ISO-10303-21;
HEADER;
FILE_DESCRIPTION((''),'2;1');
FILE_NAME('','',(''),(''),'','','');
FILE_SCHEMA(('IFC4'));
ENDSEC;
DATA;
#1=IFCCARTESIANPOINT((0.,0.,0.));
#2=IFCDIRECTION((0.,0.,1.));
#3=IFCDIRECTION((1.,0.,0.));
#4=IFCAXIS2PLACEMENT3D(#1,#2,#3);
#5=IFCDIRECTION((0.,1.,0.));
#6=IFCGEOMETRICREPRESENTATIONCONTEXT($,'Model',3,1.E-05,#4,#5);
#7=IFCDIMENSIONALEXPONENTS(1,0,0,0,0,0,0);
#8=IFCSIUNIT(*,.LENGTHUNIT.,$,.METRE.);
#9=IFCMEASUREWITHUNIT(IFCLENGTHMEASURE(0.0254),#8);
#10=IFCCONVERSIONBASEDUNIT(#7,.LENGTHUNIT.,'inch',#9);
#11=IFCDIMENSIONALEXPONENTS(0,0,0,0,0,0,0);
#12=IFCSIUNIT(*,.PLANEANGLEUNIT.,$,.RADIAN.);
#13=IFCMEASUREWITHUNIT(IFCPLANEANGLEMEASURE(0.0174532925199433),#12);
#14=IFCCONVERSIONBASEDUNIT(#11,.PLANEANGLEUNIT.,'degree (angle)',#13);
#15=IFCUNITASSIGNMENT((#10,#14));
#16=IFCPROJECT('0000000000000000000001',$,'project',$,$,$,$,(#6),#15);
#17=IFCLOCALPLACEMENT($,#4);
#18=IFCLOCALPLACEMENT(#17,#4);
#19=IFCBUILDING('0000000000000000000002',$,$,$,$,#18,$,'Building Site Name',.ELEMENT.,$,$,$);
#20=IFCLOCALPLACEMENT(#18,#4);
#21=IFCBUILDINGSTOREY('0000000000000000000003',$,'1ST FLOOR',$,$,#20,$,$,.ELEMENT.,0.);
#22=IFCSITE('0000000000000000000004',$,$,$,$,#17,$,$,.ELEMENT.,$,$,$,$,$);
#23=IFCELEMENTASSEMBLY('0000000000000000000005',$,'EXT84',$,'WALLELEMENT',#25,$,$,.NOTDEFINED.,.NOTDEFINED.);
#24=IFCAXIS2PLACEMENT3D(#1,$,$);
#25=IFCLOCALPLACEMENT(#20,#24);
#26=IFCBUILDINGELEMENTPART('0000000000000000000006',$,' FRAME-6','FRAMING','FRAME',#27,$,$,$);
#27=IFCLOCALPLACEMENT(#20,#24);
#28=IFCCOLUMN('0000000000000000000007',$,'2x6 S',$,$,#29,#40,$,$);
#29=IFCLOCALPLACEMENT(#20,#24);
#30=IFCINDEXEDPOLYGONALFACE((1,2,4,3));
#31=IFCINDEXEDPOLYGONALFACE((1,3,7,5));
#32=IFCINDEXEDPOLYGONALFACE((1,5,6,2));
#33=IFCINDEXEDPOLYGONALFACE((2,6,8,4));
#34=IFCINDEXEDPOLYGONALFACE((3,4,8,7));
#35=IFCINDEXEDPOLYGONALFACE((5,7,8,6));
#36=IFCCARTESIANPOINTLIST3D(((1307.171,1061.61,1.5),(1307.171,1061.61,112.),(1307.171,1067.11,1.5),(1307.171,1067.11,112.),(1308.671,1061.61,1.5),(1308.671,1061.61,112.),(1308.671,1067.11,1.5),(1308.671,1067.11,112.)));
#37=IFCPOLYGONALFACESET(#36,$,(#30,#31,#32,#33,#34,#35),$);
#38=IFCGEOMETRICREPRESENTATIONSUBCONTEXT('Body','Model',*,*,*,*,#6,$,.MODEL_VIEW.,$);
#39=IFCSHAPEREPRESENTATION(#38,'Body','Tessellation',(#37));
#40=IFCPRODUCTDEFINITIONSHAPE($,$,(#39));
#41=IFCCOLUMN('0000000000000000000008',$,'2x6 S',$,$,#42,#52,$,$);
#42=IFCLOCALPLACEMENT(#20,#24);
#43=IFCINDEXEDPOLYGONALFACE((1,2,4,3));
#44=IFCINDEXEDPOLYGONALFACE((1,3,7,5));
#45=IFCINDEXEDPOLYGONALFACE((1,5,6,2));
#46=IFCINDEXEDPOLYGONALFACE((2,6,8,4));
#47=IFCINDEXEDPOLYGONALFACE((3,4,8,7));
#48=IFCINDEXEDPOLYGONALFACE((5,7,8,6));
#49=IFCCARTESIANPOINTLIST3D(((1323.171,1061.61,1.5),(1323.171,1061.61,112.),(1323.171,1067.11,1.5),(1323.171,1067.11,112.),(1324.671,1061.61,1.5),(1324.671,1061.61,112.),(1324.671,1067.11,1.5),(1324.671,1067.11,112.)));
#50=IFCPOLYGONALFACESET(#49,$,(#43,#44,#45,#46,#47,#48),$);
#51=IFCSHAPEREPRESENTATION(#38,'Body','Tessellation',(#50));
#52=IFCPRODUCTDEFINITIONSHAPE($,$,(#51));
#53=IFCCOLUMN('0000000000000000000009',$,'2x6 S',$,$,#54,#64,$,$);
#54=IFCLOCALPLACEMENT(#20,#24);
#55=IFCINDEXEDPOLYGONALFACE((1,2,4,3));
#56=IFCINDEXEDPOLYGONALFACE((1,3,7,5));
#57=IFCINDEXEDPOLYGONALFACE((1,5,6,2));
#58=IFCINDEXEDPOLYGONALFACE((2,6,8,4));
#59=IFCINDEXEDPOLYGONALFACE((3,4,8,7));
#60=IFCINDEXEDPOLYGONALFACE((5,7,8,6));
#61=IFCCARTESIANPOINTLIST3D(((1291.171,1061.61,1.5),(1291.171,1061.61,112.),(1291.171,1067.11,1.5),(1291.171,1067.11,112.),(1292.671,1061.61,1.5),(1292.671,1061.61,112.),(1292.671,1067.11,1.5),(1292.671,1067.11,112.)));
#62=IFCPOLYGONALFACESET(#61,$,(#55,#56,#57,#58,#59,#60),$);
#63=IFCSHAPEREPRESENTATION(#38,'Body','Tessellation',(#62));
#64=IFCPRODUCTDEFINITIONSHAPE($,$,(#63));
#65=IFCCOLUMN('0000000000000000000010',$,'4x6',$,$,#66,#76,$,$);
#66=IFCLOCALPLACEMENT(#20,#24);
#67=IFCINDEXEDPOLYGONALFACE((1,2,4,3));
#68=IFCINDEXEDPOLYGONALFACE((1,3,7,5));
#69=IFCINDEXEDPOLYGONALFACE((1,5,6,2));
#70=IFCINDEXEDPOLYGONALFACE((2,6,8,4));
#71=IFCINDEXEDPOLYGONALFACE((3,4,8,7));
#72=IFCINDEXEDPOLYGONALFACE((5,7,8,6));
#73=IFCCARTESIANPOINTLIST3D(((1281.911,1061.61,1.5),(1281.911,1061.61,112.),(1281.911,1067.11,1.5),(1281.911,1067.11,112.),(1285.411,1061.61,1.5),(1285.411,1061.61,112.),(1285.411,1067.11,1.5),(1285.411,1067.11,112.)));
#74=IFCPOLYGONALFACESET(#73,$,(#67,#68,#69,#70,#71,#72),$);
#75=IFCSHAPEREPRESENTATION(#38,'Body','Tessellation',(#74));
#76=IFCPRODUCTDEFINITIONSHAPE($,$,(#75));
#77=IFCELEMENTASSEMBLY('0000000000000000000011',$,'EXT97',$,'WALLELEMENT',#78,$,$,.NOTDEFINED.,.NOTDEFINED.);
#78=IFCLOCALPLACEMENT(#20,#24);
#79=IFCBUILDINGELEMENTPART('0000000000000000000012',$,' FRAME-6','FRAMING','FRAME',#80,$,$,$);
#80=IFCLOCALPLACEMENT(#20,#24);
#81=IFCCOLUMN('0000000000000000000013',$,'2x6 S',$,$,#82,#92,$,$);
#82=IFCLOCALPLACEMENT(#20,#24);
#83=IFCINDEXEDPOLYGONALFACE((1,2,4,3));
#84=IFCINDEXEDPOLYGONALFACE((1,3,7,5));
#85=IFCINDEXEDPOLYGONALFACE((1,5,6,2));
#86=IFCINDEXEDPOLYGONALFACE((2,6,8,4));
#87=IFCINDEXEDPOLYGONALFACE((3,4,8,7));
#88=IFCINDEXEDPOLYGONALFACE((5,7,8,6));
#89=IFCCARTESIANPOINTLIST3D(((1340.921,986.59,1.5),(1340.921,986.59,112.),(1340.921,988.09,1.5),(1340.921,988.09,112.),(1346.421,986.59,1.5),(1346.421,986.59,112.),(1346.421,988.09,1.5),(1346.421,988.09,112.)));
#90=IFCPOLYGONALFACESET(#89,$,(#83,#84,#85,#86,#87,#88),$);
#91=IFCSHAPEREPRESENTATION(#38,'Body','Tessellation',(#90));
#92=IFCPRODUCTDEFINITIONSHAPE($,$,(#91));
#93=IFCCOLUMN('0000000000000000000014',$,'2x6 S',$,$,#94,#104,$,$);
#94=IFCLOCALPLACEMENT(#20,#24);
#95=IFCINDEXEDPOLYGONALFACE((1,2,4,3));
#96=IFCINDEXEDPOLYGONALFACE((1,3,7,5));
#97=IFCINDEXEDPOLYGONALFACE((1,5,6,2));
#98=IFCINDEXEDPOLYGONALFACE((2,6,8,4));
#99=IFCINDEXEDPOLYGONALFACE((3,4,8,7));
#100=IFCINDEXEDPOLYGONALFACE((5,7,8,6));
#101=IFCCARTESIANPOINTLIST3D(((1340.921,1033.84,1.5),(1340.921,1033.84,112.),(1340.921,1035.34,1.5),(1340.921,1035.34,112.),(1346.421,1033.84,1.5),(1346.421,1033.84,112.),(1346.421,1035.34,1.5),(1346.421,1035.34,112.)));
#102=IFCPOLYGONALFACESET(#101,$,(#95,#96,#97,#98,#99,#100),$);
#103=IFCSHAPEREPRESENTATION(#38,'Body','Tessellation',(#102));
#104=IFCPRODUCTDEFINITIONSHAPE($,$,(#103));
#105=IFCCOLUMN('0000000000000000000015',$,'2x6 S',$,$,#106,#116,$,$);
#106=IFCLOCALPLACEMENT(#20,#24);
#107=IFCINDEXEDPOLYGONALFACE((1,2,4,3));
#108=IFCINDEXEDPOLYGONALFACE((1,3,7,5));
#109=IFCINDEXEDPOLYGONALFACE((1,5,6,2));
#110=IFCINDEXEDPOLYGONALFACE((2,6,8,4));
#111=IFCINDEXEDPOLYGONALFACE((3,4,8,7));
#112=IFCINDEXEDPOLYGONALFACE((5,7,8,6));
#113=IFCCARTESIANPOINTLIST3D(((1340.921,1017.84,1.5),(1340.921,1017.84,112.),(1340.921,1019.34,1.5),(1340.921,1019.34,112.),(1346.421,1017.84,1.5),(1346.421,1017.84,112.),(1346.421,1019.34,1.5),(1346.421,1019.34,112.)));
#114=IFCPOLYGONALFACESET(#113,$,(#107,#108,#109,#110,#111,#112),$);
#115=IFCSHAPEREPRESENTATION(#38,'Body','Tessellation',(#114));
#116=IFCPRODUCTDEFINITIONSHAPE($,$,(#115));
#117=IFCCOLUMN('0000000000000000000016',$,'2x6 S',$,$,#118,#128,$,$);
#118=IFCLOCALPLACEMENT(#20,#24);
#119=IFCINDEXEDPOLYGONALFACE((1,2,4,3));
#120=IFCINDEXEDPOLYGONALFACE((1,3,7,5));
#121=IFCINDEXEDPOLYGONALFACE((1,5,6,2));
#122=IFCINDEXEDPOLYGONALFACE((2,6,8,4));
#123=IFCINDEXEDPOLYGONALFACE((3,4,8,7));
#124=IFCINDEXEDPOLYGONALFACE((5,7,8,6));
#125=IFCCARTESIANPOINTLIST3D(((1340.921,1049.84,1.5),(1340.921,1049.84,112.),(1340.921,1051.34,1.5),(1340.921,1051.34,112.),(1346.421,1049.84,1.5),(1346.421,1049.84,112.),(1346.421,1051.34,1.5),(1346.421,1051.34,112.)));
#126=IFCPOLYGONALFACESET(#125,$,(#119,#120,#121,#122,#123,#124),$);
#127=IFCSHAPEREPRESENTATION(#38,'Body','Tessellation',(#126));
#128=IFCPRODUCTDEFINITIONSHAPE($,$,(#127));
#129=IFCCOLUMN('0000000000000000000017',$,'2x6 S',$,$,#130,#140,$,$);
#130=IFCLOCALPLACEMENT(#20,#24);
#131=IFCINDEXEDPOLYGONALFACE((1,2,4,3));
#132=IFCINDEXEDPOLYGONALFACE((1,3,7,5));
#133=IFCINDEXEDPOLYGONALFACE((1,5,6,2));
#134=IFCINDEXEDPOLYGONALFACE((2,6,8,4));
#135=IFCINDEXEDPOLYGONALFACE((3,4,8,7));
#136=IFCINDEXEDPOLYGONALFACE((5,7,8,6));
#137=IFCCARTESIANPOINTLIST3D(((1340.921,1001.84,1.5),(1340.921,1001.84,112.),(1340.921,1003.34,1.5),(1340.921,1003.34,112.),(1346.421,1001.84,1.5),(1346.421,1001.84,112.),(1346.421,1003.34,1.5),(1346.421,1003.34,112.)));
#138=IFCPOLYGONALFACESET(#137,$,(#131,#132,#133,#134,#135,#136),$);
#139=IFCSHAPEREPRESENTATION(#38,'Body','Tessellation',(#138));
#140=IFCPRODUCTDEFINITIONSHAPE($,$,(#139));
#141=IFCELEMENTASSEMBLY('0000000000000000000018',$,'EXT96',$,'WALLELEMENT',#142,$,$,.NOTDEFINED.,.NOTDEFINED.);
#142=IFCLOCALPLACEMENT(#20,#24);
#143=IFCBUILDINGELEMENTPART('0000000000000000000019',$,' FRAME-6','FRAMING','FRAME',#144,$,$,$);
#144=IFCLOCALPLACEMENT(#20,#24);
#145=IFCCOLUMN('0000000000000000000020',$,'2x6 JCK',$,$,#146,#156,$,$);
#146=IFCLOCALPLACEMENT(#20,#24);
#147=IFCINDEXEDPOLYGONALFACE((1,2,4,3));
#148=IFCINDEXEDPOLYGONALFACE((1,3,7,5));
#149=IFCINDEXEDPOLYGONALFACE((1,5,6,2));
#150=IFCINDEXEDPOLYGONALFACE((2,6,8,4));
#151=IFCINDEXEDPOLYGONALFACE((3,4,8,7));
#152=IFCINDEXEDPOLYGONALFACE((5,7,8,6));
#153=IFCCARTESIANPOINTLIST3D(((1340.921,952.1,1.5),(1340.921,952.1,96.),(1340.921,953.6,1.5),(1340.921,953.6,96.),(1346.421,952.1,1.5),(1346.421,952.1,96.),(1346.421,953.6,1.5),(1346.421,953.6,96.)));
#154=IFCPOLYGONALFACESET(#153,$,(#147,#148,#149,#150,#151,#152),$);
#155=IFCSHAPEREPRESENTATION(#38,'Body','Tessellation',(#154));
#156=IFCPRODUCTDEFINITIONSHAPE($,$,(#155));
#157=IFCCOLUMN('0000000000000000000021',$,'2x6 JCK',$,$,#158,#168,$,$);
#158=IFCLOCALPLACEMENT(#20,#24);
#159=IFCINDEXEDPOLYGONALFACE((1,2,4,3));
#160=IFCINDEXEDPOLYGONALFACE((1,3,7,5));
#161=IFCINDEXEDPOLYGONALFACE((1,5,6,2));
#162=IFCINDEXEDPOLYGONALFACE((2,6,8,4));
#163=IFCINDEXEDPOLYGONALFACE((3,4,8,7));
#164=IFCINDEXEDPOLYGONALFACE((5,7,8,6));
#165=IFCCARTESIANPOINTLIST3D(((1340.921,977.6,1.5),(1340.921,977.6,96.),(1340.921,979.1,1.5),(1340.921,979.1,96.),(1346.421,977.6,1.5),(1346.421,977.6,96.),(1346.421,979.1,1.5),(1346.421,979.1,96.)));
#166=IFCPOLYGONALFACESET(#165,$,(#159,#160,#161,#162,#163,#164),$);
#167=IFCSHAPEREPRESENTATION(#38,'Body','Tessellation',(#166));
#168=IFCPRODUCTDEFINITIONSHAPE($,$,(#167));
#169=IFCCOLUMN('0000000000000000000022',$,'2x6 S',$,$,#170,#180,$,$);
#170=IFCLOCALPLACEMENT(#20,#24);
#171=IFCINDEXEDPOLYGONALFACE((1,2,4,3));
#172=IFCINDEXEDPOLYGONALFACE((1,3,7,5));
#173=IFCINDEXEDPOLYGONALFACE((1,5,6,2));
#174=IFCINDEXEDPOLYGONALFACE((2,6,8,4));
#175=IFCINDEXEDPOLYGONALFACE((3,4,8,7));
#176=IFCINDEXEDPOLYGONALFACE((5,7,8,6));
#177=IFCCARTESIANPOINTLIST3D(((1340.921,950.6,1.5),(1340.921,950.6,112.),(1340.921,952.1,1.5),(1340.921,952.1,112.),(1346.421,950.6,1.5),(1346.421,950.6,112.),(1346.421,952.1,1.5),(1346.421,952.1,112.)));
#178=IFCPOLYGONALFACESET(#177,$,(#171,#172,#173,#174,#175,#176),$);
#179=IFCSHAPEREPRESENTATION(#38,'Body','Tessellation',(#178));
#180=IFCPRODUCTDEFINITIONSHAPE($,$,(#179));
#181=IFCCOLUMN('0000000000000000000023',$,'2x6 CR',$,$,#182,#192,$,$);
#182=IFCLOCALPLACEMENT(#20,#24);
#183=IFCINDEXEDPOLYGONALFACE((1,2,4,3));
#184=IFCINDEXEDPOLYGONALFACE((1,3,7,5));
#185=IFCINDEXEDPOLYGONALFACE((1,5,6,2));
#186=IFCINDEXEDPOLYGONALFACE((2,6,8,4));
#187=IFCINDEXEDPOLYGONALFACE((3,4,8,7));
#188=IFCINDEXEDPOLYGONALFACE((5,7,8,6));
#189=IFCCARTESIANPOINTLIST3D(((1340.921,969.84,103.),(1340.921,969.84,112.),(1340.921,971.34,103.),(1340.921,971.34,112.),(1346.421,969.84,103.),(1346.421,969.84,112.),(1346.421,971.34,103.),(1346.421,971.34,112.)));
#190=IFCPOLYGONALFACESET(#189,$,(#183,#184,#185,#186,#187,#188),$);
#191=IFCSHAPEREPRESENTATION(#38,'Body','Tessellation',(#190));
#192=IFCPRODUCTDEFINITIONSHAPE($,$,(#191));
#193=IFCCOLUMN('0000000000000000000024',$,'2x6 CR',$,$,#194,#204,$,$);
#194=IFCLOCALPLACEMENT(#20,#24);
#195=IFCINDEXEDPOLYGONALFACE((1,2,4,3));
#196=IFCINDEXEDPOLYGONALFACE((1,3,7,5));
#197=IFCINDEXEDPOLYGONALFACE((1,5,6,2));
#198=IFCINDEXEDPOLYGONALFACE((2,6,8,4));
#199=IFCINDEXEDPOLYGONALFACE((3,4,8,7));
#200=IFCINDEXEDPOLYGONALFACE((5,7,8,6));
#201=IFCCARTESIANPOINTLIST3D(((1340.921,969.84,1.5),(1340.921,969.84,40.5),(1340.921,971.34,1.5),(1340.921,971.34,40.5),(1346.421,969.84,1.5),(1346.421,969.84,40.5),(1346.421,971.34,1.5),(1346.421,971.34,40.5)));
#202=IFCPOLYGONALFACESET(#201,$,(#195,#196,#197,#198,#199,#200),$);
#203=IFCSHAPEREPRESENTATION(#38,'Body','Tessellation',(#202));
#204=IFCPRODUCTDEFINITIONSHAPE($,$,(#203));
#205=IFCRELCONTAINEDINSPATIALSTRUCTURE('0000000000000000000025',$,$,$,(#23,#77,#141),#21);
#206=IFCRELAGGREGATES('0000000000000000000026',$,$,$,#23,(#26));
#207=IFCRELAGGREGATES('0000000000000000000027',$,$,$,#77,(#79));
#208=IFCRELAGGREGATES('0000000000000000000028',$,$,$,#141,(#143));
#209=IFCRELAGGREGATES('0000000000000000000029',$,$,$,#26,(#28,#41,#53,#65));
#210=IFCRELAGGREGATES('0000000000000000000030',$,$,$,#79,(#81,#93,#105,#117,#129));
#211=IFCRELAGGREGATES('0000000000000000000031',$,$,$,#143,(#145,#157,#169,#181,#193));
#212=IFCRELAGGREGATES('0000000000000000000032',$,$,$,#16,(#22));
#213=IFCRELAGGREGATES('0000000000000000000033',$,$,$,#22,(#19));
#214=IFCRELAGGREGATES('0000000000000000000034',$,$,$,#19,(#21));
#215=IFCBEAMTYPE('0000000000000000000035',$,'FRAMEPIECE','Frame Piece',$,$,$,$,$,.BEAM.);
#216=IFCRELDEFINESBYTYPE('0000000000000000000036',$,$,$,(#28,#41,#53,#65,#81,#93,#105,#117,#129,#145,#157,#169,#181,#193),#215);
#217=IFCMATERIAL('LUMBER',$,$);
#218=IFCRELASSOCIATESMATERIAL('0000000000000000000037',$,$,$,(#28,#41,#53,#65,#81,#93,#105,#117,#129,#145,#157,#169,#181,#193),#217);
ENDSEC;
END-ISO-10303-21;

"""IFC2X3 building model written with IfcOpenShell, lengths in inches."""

from ifc_helpers import new_model, entity, si_unit, converted_unit, direction, frame, frame_2d, origin_with_axes, place, context, subcontext, project, spatial, polyline, segment, composite_curve, rectangle, outline, extrude, material, type_object, element, aggregate, save


model = new_model("IFC2X3")

# Units and contexts
model_context = context("Model", 3, precision=1e-05, world=origin_with_axes(), true_north=direction((0.0, 1.0, 0.0)))
body_context = subcontext(model_context, "Body", "Model", "MODEL_VIEW")
ifc_project = project(units=[converted_unit("LENGTHUNIT", "inch", entity("IfcLengthMeasure", 0.0254), si_unit("LENGTHUNIT", "METRE"), dimensions=[1, 0, 0, 0, 0, 0, 0]), converted_unit("PLANEANGLEUNIT", "degree (angle)", entity("IfcPlaneAngleMeasure", 0.0174532925199433), si_unit("PLANEANGLEUNIT", "RADIAN"), dimensions=[0, 0, 0, 0, 0, 0, 0])], contexts=[model_context])

# Site, building, storey
site_placement = place(None, origin_with_axes())
site = spatial("IfcSite", under=ifc_project, at=site_placement, CompositionType="ELEMENT")
building_placement = place(site_placement, origin_with_axes())
building = spatial("IfcBuilding", under=site, at=building_placement, LongName="Building Site Name", CompositionType="ELEMENT")
storey_placement = place(building_placement, origin_with_axes())
storey = spatial("IfcBuildingStorey", under=building, at=storey_placement, Name="1ST FLOOR", CompositionType="ELEMENT", Elevation=0.0)

# Element assemblies, building element parts, columns
assembly_1_placement = place(storey_placement, origin_with_axes())
assembly_1 = element("IfcElementAssembly", 1, at=assembly_1_placement, inside=storey, Name="EXT84", ObjectType="WALLELEMENT", AssemblyPlace="NOTDEFINED", PredefinedType="NOTDEFINED")
building_element_part_1 = element("IfcBuildingElementPart", 2, Name=" FRAME-6", Description="FRAMING", ObjectType="FRAME")
aggregate(assembly_1, [building_element_part_1])
ifc_material_1 = material(Name="LUMBER")
beam_type = type_object("IfcBeamType", Name="FRAMEPIECE", Description="Frame Piece", PredefinedType="BEAM")
column_1_placement = place(assembly_1_placement, frame((1307.921, 1064.36, 112.0), z_axis=(0.0, 0.0, -1.0), x_axis=(-1.0, 0.0, 0.0)))
column_1 = element("IfcColumn", 3, at=column_1_placement, type_object=beam_type, material=ifc_material_1, Name="2x6 S", context=body_context, shape_type="SweptSolid", body=[
    extrude(rectangle(XDim=1.5, YDim=5.5, at=frame_2d((0.0, 0.0), x_axis=(-1.0, 0.0))), origin_with_axes(), (0.0, 0.0, 1.0), 110.5),
])
column_2_placement = place(assembly_1_placement, frame((1323.921, 1064.36, 112.0), z_axis=(0.0, 0.0, -1.0), x_axis=(-1.0, 0.0, 0.0)))
column_2 = element("IfcColumn", 4, at=column_2_placement, type_object=beam_type, material=ifc_material_1, Name="2x6 S", context=body_context, shape_type="SweptSolid", body=[
    extrude(rectangle(XDim=1.5, YDim=5.5, at=frame_2d((0.0, 0.0), x_axis=(-1.0, 0.0))), origin_with_axes(), (0.0, 0.0, 1.0), 110.5),
])
column_3_placement = place(assembly_1_placement, frame((1291.921, 1064.36, 112.0), z_axis=(0.0, 0.0, -1.0), x_axis=(-1.0, 0.0, 0.0)))
column_3 = element("IfcColumn", 5, at=column_3_placement, type_object=beam_type, material=ifc_material_1, Name="2x6 S", context=body_context, shape_type="SweptSolid", body=[
    extrude(rectangle(XDim=1.5, YDim=5.5, at=frame_2d((0.0, 0.0), x_axis=(-1.0, 0.0))), origin_with_axes(), (0.0, 0.0, 1.0), 110.5),
])
column_4_placement = place(assembly_1_placement, frame((1283.661, 1064.36, 112.0), z_axis=(0.0, 0.0, -1.0), x_axis=(-1.0, 0.0, 0.0)))
column_4 = element("IfcColumn", 6, at=column_4_placement, type_object=beam_type, material=ifc_material_1, Name="4x6", context=body_context, shape_type="SweptSolid", body=[
    extrude(outline(composite_curve([segment(polyline([(-1.75, -2.75), (-1.75, 2.75), (1.75, 2.75), (1.75, -2.75), (-1.75, -2.75)]), True, "CONTINUOUS")], self_intersect=False)), origin_with_axes(), (0.0, 0.0, 1.0), 110.5),
])
assembly_2_placement = place(storey_placement, origin_with_axes())
assembly_2 = element("IfcElementAssembly", 7, at=assembly_2_placement, inside=storey, Name="EXT97", ObjectType="WALLELEMENT", AssemblyPlace="NOTDEFINED", PredefinedType="NOTDEFINED")
building_element_part_2 = element("IfcBuildingElementPart", 8, Name=" FRAME-6", Description="FRAMING", ObjectType="FRAME")
aggregate(assembly_2, [building_element_part_2])
column_5_placement = place(assembly_2_placement, frame((1343.671, 987.34, 112.0), z_axis=(0.0, 0.0, -1.0), x_axis=(0.0, 1.0, 0.0)))
column_5 = element("IfcColumn", 9, at=column_5_placement, type_object=beam_type, material=ifc_material_1, Name="2x6 S", context=body_context, shape_type="SweptSolid", body=[
    extrude(rectangle(XDim=1.5, YDim=5.5, at=frame_2d((0.0, 0.0), x_axis=(-1.0, 0.0))), origin_with_axes(), (0.0, 0.0, 1.0), 110.5),
])
column_6_placement = place(assembly_2_placement, frame((1343.671, 1034.59, 112.0), z_axis=(0.0, 0.0, -1.0), x_axis=(0.0, 1.0, 0.0)))
column_6 = element("IfcColumn", 10, at=column_6_placement, type_object=beam_type, material=ifc_material_1, Name="2x6 S", context=body_context, shape_type="SweptSolid", body=[
    extrude(rectangle(XDim=1.5, YDim=5.5, at=frame_2d((0.0, 0.0), x_axis=(-1.0, 0.0))), origin_with_axes(), (0.0, 0.0, 1.0), 110.5),
])
column_7_placement = place(assembly_2_placement, frame((1343.671, 1018.59, 112.0), z_axis=(0.0, 0.0, -1.0), x_axis=(0.0, 1.0, 0.0)))
column_7 = element("IfcColumn", 11, at=column_7_placement, type_object=beam_type, material=ifc_material_1, Name="2x6 S", context=body_context, shape_type="SweptSolid", body=[
    extrude(rectangle(XDim=1.5, YDim=5.5, at=frame_2d((0.0, 0.0), x_axis=(-1.0, 0.0))), origin_with_axes(), (0.0, 0.0, 1.0), 110.5),
])
column_8_placement = place(assembly_2_placement, frame((1343.671, 1050.59, 112.0), z_axis=(0.0, 0.0, -1.0), x_axis=(0.0, 1.0, 0.0)))
column_8 = element("IfcColumn", 12, at=column_8_placement, type_object=beam_type, material=ifc_material_1, Name="2x6 S", context=body_context, shape_type="SweptSolid", body=[
    extrude(rectangle(XDim=1.5, YDim=5.5, at=frame_2d((0.0, 0.0), x_axis=(-1.0, 0.0))), origin_with_axes(), (0.0, 0.0, 1.0), 110.5),
])
column_9_placement = place(assembly_2_placement, frame((1343.671, 1002.59, 112.0), z_axis=(0.0, 0.0, -1.0), x_axis=(0.0, 1.0, 0.0)))
column_9 = element("IfcColumn", 13, at=column_9_placement, type_object=beam_type, material=ifc_material_1, Name="2x6 S", context=body_context, shape_type="SweptSolid", body=[
    extrude(rectangle(XDim=1.5, YDim=5.5, at=frame_2d((0.0, 0.0), x_axis=(-1.0, 0.0))), origin_with_axes(), (0.0, 0.0, 1.0), 110.5),
])
assembly_3_placement = place(storey_placement, origin_with_axes())
assembly_3 = element("IfcElementAssembly", 14, at=assembly_3_placement, inside=storey, Name="EXT96", ObjectType="WALLELEMENT", AssemblyPlace="NOTDEFINED", PredefinedType="NOTDEFINED")
building_element_part_3 = element("IfcBuildingElementPart", 15, Name=" FRAME-6", Description="FRAMING", ObjectType="FRAME")
aggregate(assembly_3, [building_element_part_3])
column_10_placement = place(assembly_3_placement, frame((1343.671, 952.85, 96.0), z_axis=(0.0, 0.0, -1.0), x_axis=(0.0, 1.0, 0.0)))
column_10 = element("IfcColumn", 16, at=column_10_placement, type_object=beam_type, material=ifc_material_1, Name="2x6 JCK", context=body_context, shape_type="SweptSolid", body=[
    extrude(rectangle(XDim=1.5, YDim=5.5, at=frame_2d((0.0, 0.0), x_axis=(-1.0, 0.0))), origin_with_axes(), (0.0, 0.0, 1.0), 94.5),
])
column_11_placement = place(assembly_3_placement, frame((1343.671, 978.35, 1.5), z_axis=(0.0, 0.0, 1.0), x_axis=(0.0, -1.0, 0.0)))
column_11 = element("IfcColumn", 17, at=column_11_placement, type_object=beam_type, material=ifc_material_1, Name="2x6 JCK", context=body_context, shape_type="SweptSolid", body=[
    extrude(rectangle(XDim=1.5, YDim=5.5, at=frame_2d((0.0, 0.0), x_axis=(-1.0, 0.0))), frame((0.0, 0.0, 0.0), z_axis=(0.0, 0.0, 1.0), x_axis=(1.0, 0.0, 0.0)), (0.0, 0.0, 1.0), 94.5),
])
column_12_placement = place(assembly_3_placement, frame((1343.671, 951.35, 112.0), z_axis=(0.0, 0.0, -1.0), x_axis=(0.0, 1.0, 0.0)))
column_12 = element("IfcColumn", 18, at=column_12_placement, type_object=beam_type, material=ifc_material_1, Name="2x6 S", context=body_context, shape_type="SweptSolid", body=[
    extrude(rectangle(XDim=1.5, YDim=5.5, at=frame_2d((0.0, 0.0), x_axis=(-1.0, 0.0))), origin_with_axes(), (0.0, 0.0, 1.0), 110.5),
])
column_13_placement = place(assembly_3_placement, frame((1343.671, 970.59, 112.0), z_axis=(0.0, 0.0, -1.0), x_axis=(0.0, 1.0, 0.0)))
column_13 = element("IfcColumn", 19, at=column_13_placement, type_object=beam_type, material=ifc_material_1, Name="2x6 CR", context=body_context, shape_type="SweptSolid", body=[
    extrude(rectangle(XDim=1.5, YDim=5.5, at=frame_2d((0.0, 0.0), x_axis=(-1.0, 0.0))), origin_with_axes(), (0.0, 0.0, 1.0), 9.0),
])
column_14_placement = place(assembly_3_placement, frame((1343.671, 970.59, 40.5), z_axis=(0.0, 0.0, -1.0), x_axis=(0.0, 1.0, 0.0)))
column_14 = element("IfcColumn", 20, at=column_14_placement, type_object=beam_type, material=ifc_material_1, Name="2x6 CR", context=body_context, shape_type="SweptSolid", body=[
    extrude(rectangle(XDim=1.5, YDim=5.5, at=frame_2d((0.0, 0.0), x_axis=(-1.0, 0.0))), origin_with_axes(), (0.0, 0.0, 1.0), 39.0),
])

aggregate(building_element_part_1, [column_1, column_2, column_3, column_4])
aggregate(building_element_part_2, [column_5, column_6, column_7, column_8, column_9])
aggregate(building_element_part_3, [column_10, column_11, column_12, column_13, column_14])

save(model, "model.ifc")
